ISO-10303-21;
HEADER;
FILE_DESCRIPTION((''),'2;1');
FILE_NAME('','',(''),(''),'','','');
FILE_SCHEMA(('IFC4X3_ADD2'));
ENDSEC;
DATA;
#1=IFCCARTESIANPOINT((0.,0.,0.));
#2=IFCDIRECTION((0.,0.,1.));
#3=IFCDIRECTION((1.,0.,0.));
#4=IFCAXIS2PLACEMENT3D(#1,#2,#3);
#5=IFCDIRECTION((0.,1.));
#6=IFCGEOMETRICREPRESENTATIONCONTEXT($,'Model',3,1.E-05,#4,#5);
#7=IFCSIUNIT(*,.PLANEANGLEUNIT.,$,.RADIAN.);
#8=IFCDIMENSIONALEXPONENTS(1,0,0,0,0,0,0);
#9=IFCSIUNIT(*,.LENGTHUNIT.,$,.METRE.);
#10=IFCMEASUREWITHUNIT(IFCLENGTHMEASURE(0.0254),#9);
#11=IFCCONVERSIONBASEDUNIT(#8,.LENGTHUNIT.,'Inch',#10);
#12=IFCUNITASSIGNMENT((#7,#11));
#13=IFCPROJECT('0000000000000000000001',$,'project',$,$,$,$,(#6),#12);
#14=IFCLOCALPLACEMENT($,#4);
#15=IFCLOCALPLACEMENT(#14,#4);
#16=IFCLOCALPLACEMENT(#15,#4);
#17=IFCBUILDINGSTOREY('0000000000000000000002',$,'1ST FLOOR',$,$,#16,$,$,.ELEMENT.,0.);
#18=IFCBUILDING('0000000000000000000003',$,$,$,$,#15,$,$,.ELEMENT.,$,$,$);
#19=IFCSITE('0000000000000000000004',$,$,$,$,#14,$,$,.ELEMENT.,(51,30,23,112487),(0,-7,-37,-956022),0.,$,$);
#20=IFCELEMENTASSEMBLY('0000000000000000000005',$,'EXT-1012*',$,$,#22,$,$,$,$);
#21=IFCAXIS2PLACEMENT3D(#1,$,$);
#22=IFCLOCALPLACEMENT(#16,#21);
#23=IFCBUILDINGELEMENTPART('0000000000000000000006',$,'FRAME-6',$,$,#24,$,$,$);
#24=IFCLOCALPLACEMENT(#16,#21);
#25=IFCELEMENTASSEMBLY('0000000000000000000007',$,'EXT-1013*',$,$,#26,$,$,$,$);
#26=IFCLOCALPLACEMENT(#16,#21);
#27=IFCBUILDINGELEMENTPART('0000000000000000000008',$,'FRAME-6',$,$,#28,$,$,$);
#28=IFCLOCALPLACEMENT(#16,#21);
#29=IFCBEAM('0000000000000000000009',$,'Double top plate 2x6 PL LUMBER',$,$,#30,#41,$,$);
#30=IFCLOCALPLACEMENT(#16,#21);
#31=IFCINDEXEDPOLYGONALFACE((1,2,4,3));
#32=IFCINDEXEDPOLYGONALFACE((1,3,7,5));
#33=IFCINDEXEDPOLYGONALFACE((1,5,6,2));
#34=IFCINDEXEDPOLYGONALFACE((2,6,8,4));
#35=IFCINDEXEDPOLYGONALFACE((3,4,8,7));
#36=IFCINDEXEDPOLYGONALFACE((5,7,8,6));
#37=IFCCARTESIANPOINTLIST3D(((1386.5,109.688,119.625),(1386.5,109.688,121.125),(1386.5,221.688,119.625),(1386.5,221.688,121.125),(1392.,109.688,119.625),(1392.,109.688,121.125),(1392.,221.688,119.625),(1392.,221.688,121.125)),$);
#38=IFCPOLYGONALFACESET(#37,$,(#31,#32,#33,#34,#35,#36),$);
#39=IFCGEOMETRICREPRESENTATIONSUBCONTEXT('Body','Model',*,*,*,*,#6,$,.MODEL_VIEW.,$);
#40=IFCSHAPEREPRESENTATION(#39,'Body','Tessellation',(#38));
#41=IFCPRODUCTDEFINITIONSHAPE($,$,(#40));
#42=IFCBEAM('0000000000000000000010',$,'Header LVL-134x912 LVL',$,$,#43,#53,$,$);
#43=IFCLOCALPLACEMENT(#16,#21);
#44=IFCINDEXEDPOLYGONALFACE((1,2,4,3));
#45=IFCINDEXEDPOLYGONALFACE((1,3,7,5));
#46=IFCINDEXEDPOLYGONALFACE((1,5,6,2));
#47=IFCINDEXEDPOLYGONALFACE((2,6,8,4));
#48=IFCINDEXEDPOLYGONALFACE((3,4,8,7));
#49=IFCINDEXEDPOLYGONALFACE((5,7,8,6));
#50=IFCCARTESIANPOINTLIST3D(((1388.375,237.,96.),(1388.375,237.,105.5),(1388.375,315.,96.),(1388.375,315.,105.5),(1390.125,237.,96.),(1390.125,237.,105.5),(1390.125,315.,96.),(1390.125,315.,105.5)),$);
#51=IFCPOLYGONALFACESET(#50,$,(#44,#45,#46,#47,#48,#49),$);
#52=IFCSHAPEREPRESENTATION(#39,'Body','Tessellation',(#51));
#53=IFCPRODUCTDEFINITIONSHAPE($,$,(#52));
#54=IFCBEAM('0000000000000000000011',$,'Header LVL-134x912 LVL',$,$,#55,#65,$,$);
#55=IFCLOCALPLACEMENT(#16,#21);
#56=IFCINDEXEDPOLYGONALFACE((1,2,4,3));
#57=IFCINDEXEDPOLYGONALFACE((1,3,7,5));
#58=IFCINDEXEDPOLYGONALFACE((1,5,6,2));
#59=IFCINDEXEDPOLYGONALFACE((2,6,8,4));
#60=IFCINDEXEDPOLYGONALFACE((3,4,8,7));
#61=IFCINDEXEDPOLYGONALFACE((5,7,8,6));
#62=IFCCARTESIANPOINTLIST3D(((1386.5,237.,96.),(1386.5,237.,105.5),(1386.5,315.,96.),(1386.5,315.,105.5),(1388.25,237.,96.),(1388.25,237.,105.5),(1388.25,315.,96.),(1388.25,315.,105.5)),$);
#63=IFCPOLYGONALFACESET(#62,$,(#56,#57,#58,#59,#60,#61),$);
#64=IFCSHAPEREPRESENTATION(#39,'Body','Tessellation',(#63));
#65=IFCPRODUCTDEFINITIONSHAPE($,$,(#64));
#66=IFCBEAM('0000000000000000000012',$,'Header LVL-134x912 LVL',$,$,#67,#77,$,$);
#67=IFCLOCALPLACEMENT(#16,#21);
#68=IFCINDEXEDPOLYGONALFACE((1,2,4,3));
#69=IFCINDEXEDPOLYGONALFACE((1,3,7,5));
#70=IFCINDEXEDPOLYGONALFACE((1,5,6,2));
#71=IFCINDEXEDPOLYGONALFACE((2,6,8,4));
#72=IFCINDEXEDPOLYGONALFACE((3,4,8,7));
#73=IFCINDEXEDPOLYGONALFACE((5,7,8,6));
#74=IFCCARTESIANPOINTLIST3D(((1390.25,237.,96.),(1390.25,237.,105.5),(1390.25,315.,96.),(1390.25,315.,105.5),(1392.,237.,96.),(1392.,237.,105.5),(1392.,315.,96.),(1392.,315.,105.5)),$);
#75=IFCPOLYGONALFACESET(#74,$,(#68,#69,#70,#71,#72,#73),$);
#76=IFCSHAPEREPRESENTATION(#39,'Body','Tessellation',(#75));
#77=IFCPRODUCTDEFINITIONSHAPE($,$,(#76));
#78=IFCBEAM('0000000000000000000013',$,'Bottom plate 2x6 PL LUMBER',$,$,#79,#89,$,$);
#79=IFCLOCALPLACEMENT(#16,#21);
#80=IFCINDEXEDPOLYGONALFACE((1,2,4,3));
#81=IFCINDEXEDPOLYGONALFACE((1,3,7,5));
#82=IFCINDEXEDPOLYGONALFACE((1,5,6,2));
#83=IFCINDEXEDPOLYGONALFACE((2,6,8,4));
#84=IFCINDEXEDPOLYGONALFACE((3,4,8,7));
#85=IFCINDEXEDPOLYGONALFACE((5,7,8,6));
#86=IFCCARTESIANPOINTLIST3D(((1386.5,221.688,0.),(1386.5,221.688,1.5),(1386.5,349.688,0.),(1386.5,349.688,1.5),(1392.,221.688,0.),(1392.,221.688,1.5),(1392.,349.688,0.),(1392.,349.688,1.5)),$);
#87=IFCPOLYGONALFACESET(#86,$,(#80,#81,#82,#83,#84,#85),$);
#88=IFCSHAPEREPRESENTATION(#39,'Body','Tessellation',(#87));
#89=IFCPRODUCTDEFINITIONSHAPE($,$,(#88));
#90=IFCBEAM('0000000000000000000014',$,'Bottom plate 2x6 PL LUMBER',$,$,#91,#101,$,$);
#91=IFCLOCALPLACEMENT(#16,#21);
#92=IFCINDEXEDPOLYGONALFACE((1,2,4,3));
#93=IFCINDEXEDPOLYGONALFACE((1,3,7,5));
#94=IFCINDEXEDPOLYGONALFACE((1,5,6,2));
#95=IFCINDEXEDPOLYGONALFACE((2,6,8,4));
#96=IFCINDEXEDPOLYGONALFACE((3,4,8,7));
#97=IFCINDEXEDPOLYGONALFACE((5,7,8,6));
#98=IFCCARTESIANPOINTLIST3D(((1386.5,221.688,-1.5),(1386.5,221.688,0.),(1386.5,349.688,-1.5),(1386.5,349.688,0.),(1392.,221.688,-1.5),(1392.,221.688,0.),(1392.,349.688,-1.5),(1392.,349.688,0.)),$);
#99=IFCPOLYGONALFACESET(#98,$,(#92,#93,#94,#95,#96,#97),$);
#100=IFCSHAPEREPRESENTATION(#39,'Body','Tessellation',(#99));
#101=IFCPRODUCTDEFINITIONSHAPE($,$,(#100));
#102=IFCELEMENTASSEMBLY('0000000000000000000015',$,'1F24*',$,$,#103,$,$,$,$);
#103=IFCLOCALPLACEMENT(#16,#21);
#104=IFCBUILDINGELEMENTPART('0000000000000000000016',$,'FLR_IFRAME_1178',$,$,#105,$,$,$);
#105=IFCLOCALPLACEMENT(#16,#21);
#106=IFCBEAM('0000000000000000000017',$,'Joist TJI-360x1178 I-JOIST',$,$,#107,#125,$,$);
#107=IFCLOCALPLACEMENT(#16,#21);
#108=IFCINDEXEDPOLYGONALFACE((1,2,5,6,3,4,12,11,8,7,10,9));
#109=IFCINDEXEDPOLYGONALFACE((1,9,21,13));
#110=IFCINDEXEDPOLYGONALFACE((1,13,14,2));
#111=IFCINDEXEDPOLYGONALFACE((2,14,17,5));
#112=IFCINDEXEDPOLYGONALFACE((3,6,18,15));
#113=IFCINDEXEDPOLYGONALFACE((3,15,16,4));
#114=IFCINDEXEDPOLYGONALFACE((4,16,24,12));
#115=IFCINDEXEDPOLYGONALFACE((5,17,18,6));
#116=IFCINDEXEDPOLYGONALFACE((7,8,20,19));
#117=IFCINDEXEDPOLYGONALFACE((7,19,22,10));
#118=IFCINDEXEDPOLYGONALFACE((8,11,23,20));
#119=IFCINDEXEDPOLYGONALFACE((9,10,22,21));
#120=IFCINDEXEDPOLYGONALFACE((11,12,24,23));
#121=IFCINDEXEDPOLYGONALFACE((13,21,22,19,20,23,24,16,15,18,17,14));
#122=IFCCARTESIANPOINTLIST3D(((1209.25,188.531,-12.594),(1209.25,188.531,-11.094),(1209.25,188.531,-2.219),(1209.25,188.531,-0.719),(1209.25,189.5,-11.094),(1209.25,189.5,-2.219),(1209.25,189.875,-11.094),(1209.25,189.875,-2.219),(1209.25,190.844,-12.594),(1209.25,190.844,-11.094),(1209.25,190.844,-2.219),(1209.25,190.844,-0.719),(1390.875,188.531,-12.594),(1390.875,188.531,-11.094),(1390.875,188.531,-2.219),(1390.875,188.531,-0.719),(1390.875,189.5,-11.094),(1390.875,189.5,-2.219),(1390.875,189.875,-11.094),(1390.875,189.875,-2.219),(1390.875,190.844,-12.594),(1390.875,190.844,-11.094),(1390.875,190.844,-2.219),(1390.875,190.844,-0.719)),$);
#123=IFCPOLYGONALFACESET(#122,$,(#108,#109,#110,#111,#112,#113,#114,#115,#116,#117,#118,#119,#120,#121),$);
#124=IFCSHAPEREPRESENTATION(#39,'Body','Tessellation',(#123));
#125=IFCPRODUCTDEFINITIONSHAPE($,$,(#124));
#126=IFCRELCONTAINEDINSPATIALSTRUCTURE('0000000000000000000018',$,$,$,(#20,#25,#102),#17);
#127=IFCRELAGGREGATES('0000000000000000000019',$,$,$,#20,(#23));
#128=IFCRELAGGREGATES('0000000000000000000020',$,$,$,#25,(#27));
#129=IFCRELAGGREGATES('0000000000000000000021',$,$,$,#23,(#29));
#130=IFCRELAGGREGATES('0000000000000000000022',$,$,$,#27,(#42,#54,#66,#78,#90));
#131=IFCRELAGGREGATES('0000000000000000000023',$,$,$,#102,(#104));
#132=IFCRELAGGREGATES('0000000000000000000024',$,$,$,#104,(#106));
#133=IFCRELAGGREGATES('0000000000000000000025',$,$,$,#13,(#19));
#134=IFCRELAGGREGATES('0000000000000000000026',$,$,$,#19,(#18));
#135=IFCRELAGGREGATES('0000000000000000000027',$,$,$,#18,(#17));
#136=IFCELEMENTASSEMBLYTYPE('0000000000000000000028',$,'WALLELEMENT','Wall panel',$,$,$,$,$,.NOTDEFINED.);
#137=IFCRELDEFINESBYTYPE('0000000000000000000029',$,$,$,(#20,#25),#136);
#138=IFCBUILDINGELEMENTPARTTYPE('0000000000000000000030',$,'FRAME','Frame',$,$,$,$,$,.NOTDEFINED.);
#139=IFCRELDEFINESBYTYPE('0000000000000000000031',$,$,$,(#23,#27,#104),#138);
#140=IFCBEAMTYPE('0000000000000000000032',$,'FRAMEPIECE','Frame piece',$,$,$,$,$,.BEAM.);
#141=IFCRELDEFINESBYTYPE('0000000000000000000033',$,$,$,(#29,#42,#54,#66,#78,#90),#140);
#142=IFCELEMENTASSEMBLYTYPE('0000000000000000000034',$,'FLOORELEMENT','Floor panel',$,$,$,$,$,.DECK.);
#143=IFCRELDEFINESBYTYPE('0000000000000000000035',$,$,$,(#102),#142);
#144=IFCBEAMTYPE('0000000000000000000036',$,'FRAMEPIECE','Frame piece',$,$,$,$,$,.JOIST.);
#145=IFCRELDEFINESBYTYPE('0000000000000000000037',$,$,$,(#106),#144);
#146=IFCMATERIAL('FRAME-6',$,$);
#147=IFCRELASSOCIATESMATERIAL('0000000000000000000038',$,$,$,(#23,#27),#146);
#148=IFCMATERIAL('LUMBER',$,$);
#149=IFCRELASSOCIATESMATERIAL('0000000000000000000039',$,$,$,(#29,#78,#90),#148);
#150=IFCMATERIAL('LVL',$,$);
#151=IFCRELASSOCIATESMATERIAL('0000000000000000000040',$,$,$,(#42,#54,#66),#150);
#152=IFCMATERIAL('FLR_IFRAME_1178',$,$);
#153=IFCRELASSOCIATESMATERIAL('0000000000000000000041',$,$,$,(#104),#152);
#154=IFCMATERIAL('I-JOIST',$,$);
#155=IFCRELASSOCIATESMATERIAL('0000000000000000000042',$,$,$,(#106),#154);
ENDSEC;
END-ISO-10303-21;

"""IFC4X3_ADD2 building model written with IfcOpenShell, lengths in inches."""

from ifc_helpers import new_model, entity, si_unit, converted_unit, direction, frame, origin_with_axes, origin_2d_with_axis, place, context, subcontext, project, spatial, rectangle, i_section, extrude, material, type_object, element, aggregate, save


model = new_model("IFC4X3_ADD2")

# Units and contexts
model_context = context("Model", 3, precision=1e-05, world=origin_with_axes(), true_north=direction((0.0, 1.0)))
body_context = subcontext(model_context, "Body", "Model", "MODEL_VIEW")
ifc_project = project(units=[si_unit("PLANEANGLEUNIT", "RADIAN"), converted_unit("LENGTHUNIT", "Inch", entity("IfcLengthMeasure", 0.0254), si_unit("LENGTHUNIT", "METRE"), dimensions=[1, 0, 0, 0, 0, 0, 0])], contexts=[model_context])

# Site, building, storey
site_placement = place(None, origin_with_axes())
site = spatial("IfcSite", under=ifc_project, at=site_placement, CompositionType="ELEMENT", RefLatitude=(51, 30, 23, 112487), RefLongitude=(0, -7, -37, -956022), RefElevation=0.0)
building_placement = place(site_placement, origin_with_axes())
building = spatial("IfcBuilding", under=site, at=building_placement, CompositionType="ELEMENT")
storey_placement = place(building_placement, origin_with_axes())
storey = spatial("IfcBuildingStorey", under=building, at=storey_placement, Name="1ST FLOOR", CompositionType="ELEMENT", Elevation=0.0)

# Element assemblies, building element parts
element_assembly_type_1 = type_object("IfcElementAssemblyType", Name="WALLELEMENT", Description="Wall panel", PredefinedType="NOTDEFINED")
assembly_1_placement = place(storey_placement, origin_with_axes())
assembly_1 = element("IfcElementAssembly", 1, at=assembly_1_placement, inside=storey, type_object=element_assembly_type_1, Name="EXT-1012*")
ifc_material_1 = material(Name="FRAME-6")
building_element_part_type = type_object("IfcBuildingElementPartType", Name="FRAME", Description="Frame", PredefinedType="NOTDEFINED")
building_element_part_1_placement = place(storey_placement, origin_with_axes())
building_element_part_1 = element("IfcBuildingElementPart", 2, at=building_element_part_1_placement, type_object=building_element_part_type, material=ifc_material_1, Name="FRAME-6")
aggregate(assembly_1, [building_element_part_1])
ifc_material_2 = material(Name="LUMBER")
assembly_2_placement = place(storey_placement, origin_with_axes())
assembly_2 = element("IfcElementAssembly", 3, at=assembly_2_placement, inside=storey, type_object=element_assembly_type_1, Name="EXT-1013*")
building_element_part_2_placement = place(storey_placement, origin_with_axes())
building_element_part_2 = element("IfcBuildingElementPart", 4, at=building_element_part_2_placement, type_object=building_element_part_type, material=ifc_material_1, Name="FRAME-6")
aggregate(assembly_2, [building_element_part_2])

# Beams
beam_type_1 = type_object("IfcBeamType", Name="FRAMEPIECE", Description="Frame piece", PredefinedType="BEAM")
beam_1_placement = place(storey_placement, frame((1389.25, 221.688, 120.375), z_axis=(0.0, -1.0, 0.0), x_axis=(0.0, 0.0, -1.0)))
beam_1 = element("IfcBeam", 5, at=beam_1_placement, type_object=beam_type_1, material=ifc_material_2, Name="Double top plate 2x6 PL LUMBER", context=body_context, shape_type="SweptSolid", body=[
    extrude(rectangle(XDim=1.5, YDim=5.5, at=origin_2d_with_axis()), origin_with_axes(), (0.0, 0.0, 1.0), 112.0),
])
aggregate(building_element_part_1, [beam_1])
ifc_material_3 = material(Name="LVL")
beam_2_placement = place(storey_placement, frame((1389.25, 237.0, 100.75), z_axis=(0.0, 1.0, 0.0), x_axis=(-1.0, 0.0, 0.0)))
beam_2 = element("IfcBeam", 6, at=beam_2_placement, type_object=beam_type_1, material=ifc_material_3, Name="Header LVL-134x912 LVL", context=body_context, shape_type="SweptSolid", body=[
    extrude(rectangle(XDim=1.75, YDim=9.5, at=origin_2d_with_axis()), origin_with_axes(), (0.0, 0.0, 1.0), 78.0),
])
beam_3_placement = place(storey_placement, frame((1387.375, 237.0, 100.75), z_axis=(0.0, 1.0, 0.0), x_axis=(-1.0, 0.0, 0.0)))
beam_3 = element("IfcBeam", 7, at=beam_3_placement, type_object=beam_type_1, material=ifc_material_3, Name="Header LVL-134x912 LVL", context=body_context, shape_type="SweptSolid", body=[
    extrude(rectangle(XDim=1.75, YDim=9.5, at=origin_2d_with_axis()), origin_with_axes(), (0.0, 0.0, 1.0), 78.0),
])
beam_4_placement = place(storey_placement, frame((1391.125, 237.0, 100.75), z_axis=(0.0, 1.0, 0.0), x_axis=(-1.0, 0.0, 0.0)))
beam_4 = element("IfcBeam", 8, at=beam_4_placement, type_object=beam_type_1, material=ifc_material_3, Name="Header LVL-134x912 LVL", context=body_context, shape_type="SweptSolid", body=[
    extrude(rectangle(XDim=1.75, YDim=9.5, at=origin_2d_with_axis()), origin_with_axes(), (0.0, 0.0, 1.0), 78.0),
])
beam_5_placement = place(storey_placement, frame((1389.25, 221.688, 0.75), z_axis=(0.0, 1.0, 0.0), x_axis=(0.0, 0.0, 1.0)))
beam_5 = element("IfcBeam", 9, at=beam_5_placement, type_object=beam_type_1, material=ifc_material_2, Name="Bottom plate 2x6 PL LUMBER", context=body_context, shape_type="SweptSolid", body=[
    extrude(rectangle(XDim=1.5, YDim=5.5, at=origin_2d_with_axis()), origin_with_axes(), (0.0, 0.0, 1.0), 128.0),
])
beam_6_placement = place(storey_placement, frame((1389.25, 221.688, -0.75), z_axis=(0.0, 1.0, 0.0), x_axis=(0.0, 0.0, 1.0)))
beam_6 = element("IfcBeam", 10, at=beam_6_placement, type_object=beam_type_1, material=ifc_material_2, Name="Bottom plate 2x6 PL LUMBER", context=body_context, shape_type="SweptSolid", body=[
    extrude(rectangle(XDim=1.5, YDim=5.5, at=origin_2d_with_axis()), origin_with_axes(), (0.0, 0.0, 1.0), 128.0),
])
aggregate(building_element_part_2, [beam_2, beam_3, beam_4, beam_5, beam_6])

# Element assembly, building element part, beam
element_assembly_type_2 = type_object("IfcElementAssemblyType", Name="FLOORELEMENT", Description="Floor panel", PredefinedType="DECK")
assembly_3_placement = place(storey_placement, origin_with_axes())
assembly_3 = element("IfcElementAssembly", 11, at=assembly_3_placement, inside=storey, type_object=element_assembly_type_2, Name="1F24*")
ifc_material_4 = material(Name="FLR_IFRAME_1178")
building_element_part_3_placement = place(storey_placement, origin_with_axes())
building_element_part_3 = element("IfcBuildingElementPart", 12, at=building_element_part_3_placement, type_object=building_element_part_type, material=ifc_material_4, Name="FLR_IFRAME_1178")
aggregate(assembly_3, [building_element_part_3])
ifc_material_5 = material(Name="I-JOIST")
beam_type_2 = type_object("IfcBeamType", Name="FRAMEPIECE", Description="Frame piece", PredefinedType="JOIST")
beam_7_placement = place(storey_placement, frame((1390.875, 189.688, -6.656), z_axis=(-1.0, 0.0, 0.0), x_axis=(0.0, -1.0, 0.0)))
beam_7 = element("IfcBeam", 13, at=beam_7_placement, type_object=beam_type_2, material=ifc_material_5, Name="Joist TJI-360x1178 I-JOIST", context=body_context, shape_type="SweptSolid", body=[
    extrude(i_section(OverallWidth=2.313, OverallDepth=11.875, WebThickness=0.375, FlangeThickness=1.5, at=origin_2d_with_axis()), origin_with_axes(), (0.0, 0.0, 1.0), 181.625),
])
aggregate(building_element_part_3, [beam_7])

save(model, "model.ifc")
